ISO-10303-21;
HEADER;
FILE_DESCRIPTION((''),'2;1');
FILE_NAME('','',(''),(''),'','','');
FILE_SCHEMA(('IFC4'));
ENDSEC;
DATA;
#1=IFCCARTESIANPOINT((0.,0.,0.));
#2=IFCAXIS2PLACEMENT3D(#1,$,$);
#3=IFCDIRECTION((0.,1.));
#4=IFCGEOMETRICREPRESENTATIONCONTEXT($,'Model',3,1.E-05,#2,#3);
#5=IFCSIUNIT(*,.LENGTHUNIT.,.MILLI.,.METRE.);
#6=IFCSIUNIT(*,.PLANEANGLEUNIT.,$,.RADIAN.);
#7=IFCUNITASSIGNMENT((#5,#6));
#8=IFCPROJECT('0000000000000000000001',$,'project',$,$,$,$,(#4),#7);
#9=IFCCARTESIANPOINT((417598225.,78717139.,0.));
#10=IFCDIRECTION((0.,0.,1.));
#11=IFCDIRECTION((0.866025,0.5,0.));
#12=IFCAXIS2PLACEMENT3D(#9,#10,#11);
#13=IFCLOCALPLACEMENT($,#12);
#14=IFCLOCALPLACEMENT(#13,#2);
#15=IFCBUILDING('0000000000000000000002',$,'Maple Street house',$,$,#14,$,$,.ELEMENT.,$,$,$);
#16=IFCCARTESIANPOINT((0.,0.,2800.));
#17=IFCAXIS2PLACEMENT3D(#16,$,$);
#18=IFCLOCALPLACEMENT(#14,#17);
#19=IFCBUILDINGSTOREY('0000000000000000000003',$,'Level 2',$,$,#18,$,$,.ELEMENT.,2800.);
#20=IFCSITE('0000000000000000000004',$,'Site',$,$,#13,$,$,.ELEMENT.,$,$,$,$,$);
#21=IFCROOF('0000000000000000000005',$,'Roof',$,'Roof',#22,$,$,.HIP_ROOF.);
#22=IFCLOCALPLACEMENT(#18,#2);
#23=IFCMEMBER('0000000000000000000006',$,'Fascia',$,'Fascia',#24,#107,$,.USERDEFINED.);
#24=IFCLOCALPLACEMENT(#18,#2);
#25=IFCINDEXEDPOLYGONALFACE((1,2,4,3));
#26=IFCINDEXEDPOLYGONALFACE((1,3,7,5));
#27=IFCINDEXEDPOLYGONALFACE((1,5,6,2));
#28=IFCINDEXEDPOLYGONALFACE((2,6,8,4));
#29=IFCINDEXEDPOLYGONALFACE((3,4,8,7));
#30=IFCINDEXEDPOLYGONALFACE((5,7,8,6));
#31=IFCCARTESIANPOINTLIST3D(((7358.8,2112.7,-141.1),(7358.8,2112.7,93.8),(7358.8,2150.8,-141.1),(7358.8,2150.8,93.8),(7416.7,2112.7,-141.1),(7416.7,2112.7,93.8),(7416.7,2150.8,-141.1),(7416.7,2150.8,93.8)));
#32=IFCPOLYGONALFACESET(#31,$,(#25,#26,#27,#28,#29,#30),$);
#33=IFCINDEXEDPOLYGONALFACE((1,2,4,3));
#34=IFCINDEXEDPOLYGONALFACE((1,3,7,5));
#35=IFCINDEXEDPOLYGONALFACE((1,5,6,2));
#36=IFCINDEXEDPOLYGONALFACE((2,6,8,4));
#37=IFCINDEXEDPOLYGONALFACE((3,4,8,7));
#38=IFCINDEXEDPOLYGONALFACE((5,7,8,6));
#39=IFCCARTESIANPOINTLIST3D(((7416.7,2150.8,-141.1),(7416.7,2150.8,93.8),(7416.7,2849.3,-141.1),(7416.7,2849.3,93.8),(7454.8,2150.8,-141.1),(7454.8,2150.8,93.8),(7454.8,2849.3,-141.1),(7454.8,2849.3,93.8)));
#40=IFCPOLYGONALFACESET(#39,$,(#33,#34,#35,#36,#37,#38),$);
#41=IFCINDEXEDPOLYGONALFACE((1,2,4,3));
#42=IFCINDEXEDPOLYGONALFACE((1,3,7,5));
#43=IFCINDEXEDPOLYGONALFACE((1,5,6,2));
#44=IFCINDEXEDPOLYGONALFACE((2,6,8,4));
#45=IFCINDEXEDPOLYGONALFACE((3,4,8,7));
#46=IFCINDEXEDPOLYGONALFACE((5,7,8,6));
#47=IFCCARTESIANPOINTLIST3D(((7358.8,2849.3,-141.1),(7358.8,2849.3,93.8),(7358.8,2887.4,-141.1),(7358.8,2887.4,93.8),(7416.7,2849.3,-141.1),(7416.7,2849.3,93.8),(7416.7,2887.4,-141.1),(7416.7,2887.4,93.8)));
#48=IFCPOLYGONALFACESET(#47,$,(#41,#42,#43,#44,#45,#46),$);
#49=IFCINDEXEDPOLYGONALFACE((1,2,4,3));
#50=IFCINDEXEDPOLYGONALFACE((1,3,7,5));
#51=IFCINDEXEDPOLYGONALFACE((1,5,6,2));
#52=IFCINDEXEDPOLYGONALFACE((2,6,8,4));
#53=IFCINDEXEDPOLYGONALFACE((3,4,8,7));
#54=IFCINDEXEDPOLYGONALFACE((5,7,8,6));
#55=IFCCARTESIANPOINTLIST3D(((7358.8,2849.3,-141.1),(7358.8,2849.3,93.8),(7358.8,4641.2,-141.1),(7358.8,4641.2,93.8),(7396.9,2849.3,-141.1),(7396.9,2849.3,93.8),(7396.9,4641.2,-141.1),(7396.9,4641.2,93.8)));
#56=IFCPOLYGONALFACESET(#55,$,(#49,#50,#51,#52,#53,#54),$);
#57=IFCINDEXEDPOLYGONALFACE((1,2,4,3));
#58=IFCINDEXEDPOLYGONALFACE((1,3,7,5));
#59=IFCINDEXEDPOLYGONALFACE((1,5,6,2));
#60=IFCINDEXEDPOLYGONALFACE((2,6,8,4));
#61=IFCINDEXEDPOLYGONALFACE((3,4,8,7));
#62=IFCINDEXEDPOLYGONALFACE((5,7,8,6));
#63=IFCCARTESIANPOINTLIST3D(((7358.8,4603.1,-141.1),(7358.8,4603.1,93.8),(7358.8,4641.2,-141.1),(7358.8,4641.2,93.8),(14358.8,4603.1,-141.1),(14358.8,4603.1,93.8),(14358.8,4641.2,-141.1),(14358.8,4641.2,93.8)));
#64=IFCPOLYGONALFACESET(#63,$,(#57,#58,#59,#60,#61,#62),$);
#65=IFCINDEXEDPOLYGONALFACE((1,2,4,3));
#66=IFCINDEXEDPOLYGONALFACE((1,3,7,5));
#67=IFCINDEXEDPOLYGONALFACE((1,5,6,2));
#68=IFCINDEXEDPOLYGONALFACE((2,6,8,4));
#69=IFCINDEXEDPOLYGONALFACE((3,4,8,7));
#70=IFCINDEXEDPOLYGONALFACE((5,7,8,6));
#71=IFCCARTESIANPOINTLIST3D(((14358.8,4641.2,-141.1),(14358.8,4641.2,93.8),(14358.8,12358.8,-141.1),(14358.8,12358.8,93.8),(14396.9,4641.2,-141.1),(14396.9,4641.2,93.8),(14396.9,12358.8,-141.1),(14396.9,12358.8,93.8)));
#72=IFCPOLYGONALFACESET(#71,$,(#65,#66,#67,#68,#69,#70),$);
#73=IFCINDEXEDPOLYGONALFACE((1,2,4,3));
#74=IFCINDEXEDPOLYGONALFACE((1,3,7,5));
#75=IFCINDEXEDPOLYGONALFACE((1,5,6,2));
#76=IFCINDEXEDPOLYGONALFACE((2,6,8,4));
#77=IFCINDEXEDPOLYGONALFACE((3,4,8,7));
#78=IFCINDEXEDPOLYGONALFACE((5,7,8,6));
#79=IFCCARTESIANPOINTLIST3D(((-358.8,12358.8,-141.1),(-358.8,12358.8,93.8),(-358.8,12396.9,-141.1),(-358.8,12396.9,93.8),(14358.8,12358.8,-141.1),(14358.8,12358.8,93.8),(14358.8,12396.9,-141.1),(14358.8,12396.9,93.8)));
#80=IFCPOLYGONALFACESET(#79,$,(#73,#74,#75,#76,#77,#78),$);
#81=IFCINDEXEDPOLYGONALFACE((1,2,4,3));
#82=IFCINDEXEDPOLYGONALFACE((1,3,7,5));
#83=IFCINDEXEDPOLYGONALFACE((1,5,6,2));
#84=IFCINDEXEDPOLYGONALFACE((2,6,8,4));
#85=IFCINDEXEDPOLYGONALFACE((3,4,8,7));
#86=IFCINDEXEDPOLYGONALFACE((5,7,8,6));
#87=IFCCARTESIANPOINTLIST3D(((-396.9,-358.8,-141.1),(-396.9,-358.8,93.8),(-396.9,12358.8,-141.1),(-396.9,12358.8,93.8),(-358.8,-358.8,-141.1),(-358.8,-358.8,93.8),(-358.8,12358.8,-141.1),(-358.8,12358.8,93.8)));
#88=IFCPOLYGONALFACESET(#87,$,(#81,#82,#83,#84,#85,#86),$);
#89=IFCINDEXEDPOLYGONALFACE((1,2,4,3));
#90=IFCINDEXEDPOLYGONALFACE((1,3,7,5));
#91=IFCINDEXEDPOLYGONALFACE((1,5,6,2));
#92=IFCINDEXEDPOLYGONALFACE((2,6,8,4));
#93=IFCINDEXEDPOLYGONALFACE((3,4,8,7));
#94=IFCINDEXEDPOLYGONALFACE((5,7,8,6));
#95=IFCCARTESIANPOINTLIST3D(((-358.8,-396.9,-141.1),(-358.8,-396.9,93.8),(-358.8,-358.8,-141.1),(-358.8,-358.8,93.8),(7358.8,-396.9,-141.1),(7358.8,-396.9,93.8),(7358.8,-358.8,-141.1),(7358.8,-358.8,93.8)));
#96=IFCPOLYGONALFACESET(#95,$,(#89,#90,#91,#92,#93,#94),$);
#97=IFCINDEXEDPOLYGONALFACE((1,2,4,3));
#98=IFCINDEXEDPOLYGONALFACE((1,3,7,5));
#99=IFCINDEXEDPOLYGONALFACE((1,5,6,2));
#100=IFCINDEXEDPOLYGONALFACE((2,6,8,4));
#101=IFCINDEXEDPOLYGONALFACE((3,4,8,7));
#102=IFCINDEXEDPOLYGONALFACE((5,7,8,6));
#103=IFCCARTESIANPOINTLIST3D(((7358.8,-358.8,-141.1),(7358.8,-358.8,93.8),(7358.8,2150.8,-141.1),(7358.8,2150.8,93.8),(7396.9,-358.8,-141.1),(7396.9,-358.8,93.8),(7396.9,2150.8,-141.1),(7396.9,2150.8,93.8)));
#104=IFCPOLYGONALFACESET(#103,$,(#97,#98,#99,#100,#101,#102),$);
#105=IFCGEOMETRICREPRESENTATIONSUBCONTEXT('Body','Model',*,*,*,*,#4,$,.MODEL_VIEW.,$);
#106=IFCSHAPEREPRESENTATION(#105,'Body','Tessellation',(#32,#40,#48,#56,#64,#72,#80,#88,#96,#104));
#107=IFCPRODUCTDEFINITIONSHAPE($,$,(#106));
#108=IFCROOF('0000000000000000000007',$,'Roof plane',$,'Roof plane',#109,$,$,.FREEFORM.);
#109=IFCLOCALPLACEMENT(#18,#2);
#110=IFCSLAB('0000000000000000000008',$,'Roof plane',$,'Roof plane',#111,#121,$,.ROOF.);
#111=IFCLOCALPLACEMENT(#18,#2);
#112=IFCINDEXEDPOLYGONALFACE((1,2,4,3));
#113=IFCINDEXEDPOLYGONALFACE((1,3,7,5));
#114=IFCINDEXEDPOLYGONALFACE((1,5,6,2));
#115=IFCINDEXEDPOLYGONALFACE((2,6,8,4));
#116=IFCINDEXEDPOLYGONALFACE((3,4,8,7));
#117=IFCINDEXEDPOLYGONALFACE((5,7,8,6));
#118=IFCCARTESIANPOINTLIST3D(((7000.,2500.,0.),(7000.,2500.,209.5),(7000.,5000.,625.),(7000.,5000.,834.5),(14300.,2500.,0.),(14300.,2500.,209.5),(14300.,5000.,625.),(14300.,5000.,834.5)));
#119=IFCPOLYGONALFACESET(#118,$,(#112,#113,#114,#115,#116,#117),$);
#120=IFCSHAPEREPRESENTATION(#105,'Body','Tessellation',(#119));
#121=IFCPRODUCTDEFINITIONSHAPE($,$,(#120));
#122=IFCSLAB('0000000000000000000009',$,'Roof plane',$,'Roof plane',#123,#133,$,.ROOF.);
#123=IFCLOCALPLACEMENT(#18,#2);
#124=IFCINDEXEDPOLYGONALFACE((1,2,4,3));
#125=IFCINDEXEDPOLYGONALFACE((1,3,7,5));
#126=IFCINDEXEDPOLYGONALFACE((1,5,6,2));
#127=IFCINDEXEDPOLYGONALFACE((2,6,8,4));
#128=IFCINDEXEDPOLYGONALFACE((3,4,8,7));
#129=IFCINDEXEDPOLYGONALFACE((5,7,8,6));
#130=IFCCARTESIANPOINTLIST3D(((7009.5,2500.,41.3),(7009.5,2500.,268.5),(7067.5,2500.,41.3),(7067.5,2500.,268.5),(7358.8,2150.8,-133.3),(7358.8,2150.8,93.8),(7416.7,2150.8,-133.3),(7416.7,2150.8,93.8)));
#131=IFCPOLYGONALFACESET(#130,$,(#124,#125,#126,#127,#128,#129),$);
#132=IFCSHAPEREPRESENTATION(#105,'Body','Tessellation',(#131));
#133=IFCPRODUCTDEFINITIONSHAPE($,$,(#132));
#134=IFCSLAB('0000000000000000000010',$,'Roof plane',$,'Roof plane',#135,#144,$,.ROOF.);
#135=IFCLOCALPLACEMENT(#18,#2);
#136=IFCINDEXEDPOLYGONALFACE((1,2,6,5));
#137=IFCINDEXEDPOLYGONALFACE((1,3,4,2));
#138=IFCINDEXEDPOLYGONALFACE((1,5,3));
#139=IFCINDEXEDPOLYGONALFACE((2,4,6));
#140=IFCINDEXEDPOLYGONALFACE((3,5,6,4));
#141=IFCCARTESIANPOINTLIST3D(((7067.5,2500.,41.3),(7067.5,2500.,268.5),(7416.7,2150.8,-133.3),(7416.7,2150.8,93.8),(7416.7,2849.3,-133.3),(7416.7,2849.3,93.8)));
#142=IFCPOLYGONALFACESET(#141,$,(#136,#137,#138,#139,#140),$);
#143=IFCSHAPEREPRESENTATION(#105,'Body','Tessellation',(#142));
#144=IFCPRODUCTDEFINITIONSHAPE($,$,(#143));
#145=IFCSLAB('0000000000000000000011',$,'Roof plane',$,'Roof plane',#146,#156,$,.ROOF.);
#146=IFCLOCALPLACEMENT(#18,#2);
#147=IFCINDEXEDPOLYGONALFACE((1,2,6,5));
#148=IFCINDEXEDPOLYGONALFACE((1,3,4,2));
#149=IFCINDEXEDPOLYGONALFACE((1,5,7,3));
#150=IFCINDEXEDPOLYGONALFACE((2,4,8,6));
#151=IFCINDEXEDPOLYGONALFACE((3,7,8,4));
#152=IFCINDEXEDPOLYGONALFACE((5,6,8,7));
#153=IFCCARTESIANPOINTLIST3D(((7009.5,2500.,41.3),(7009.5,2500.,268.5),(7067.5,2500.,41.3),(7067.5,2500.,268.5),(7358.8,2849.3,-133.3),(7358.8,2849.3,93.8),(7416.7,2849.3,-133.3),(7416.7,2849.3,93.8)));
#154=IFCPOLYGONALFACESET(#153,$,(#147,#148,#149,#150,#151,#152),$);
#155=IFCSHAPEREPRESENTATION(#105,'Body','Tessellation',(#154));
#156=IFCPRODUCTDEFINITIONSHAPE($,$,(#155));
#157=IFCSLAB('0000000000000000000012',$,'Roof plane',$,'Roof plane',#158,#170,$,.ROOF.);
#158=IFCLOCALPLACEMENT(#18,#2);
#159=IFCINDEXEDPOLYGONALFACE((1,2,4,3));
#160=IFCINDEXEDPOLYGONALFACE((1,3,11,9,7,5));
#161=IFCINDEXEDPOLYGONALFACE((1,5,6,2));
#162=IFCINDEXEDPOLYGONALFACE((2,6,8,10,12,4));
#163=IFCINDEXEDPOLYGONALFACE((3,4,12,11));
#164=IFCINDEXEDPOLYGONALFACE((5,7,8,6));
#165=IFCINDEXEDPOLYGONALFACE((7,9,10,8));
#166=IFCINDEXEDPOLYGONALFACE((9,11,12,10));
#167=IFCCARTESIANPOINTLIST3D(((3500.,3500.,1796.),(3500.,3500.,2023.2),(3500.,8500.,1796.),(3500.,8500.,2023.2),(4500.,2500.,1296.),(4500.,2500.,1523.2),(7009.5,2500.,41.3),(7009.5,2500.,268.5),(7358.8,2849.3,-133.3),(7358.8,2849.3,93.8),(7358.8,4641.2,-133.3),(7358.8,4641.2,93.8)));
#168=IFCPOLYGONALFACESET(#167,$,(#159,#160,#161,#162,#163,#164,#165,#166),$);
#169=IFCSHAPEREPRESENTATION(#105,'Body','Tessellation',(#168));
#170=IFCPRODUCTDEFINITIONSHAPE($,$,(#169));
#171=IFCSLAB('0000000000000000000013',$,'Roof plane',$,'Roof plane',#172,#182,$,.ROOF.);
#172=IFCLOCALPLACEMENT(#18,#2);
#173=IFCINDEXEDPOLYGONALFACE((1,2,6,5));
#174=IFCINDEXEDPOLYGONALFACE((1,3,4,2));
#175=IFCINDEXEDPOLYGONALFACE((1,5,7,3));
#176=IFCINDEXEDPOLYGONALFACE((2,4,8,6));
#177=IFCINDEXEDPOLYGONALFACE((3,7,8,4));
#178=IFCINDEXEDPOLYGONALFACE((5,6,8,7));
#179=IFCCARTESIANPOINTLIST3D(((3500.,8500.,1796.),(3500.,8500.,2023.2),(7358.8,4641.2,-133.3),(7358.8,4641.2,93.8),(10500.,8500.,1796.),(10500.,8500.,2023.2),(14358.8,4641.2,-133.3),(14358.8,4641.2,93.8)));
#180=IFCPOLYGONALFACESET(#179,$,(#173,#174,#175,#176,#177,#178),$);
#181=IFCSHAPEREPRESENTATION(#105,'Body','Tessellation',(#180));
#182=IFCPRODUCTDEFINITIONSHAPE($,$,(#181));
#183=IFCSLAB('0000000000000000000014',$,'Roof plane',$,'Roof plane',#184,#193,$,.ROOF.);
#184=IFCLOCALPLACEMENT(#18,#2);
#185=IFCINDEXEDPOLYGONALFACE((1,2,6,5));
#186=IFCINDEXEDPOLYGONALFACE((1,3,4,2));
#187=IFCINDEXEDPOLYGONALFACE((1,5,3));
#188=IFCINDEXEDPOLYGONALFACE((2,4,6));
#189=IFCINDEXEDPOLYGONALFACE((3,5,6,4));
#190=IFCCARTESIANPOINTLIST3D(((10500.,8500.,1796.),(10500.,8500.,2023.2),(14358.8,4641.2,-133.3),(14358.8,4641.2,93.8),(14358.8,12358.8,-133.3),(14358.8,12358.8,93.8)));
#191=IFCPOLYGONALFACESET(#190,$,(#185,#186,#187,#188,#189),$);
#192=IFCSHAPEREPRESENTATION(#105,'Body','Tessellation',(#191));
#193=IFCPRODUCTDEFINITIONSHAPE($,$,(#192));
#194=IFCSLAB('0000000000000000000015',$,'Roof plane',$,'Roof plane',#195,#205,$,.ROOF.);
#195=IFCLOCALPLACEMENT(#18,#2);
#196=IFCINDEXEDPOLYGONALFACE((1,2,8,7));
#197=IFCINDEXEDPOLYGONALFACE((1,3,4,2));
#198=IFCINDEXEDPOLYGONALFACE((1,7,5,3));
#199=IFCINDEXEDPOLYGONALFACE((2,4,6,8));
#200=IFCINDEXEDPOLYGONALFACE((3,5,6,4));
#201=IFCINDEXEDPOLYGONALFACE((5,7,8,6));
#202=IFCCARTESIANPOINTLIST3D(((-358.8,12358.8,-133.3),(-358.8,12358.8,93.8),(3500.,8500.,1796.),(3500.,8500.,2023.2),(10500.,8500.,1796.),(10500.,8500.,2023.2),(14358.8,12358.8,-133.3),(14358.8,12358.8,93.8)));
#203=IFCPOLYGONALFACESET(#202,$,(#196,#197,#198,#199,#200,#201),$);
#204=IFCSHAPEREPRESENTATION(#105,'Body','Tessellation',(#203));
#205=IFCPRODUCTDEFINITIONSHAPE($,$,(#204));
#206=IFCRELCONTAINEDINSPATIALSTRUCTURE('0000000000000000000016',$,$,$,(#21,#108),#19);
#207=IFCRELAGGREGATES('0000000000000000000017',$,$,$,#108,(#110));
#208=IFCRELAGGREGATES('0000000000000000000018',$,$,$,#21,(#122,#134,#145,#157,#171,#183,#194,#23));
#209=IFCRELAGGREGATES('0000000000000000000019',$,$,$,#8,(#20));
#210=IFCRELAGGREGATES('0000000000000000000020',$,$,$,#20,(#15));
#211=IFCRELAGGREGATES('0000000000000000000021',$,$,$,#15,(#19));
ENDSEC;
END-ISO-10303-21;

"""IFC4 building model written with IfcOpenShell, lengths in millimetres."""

from ifc_helpers import new_model, si_unit, direction, frame, origin, origin_with_axes, place, context, subcontext, project, spatial, polyline, outline, extrude, element, aggregate, save


model = new_model("IFC4")

# Units and contexts
model_context = context("Model", 3, precision=1e-05, world=origin(), true_north=direction((0.0, 1.0)))
body_context = subcontext(model_context, "Body", "Model", "MODEL_VIEW")
ifc_project = project(units=[si_unit("LENGTHUNIT", "METRE", prefix="MILLI"), si_unit("PLANEANGLEUNIT", "RADIAN")], contexts=[model_context])

# Site, building, storey
site_placement = place(None, frame((417598225.0, 78717139.0, 0.0), z_axis=(0.0, 0.0, 1.0), x_axis=(0.866025, 0.5, 0.0)))
site = spatial("IfcSite", under=ifc_project, at=site_placement, Name="Site", CompositionType="ELEMENT")
building_placement = place(site_placement, origin())
building = spatial("IfcBuilding", under=site, at=building_placement, Name="Maple Street house", CompositionType="ELEMENT")
storey_placement = place(building_placement, frame((0.0, 0.0, 2800.0)))
storey = spatial("IfcBuildingStorey", under=building, at=storey_placement, Name="Level 2", CompositionType="ELEMENT", Elevation=2800.0)

# Roof, member
roof_1_placement = place(storey_placement, origin_with_axes())
roof_1 = element("IfcRoof", 1, at=roof_1_placement, inside=storey, Name="Roof", ObjectType="Roof", PredefinedType="HIP_ROOF")
member_placement = place(storey_placement, origin_with_axes())
member = element("IfcMember", 2, at=member_placement, Name="Fascia", ObjectType="Fascia", PredefinedType="USERDEFINED", context=body_context, shape_type="SweptSolid", body=[
    extrude(outline(polyline([(0.0, -234.9), (57.9, -234.9), (57.9, 0.0), (0.0, 0.0), (0.0, -234.9)])), frame((7358.8, 2150.8, 93.8), z_axis=(0.0, -1.0, 0.0), x_axis=(1.0, 0.0, 0.0)), (0.0, 0.0, 1.0), 38.1),
    extrude(outline(polyline([(0.0, -234.9), (698.5, -234.9), (698.5, 0.0), (0.0, 0.0), (0.0, -234.9)])), frame((7416.7, 2150.8, 93.8), z_axis=(1.0, 0.0, 0.0), x_axis=(0.0, 1.0, 0.0)), (0.0, 0.0, 1.0), 38.1),
    extrude(outline(polyline([(0.0, -234.9), (57.9, -234.9), (57.9, 0.0), (0.0, 0.0), (0.0, -234.9)])), frame((7416.7, 2849.3, 93.8), z_axis=(0.0, 1.0, 0.0), x_axis=(-1.0, 0.0, 0.0)), (0.0, 0.0, 1.0), 38.1),
    extrude(outline(polyline([(0.0, -234.9), (1792.0, -234.9), (1792.0, 0.0), (0.0, 0.0), (0.0, -234.9)])), frame((7358.8, 2849.3, 93.8), z_axis=(1.0, 0.0, 0.0), x_axis=(0.0, 1.0, 0.0)), (0.0, 0.0, 1.0), 38.1),
    extrude(outline(polyline([(0.0, -234.9), (7000.0, -234.9), (7000.0, 0.0), (0.0, 0.0), (0.0, -234.9)])), frame((7358.8, 4641.2, 93.8), z_axis=(0.0, -1.0, 0.0), x_axis=(1.0, 0.0, 0.0)), (0.0, 0.0, 1.0), 38.1),
    extrude(outline(polyline([(0.0, -234.9), (7717.6, -234.9), (7717.6, 0.0), (0.0, 0.0), (0.0, -234.9)])), frame((14358.8, 4641.2, 93.8), z_axis=(1.0, 0.0, 0.0), x_axis=(0.0, 1.0, 0.0)), (0.0, 0.0, 1.0), 38.1),
    extrude(outline(polyline([(0.0, -234.9), (14717.5, -234.9), (14717.5, 0.0), (0.0, 0.0), (0.0, -234.9)])), frame((14358.8, 12358.8, 93.8), z_axis=(0.0, 1.0, 0.0), x_axis=(-1.0, 0.0, 0.0)), (0.0, 0.0, 1.0), 38.1),
    extrude(outline(polyline([(0.0, -234.9), (12717.5, -234.9), (12717.5, 0.0), (0.0, 0.0), (0.0, -234.9)])), frame((-358.8, 12358.8, 93.8), z_axis=(-1.0, 0.0, 0.0), x_axis=(0.0, -1.0, 0.0)), (0.0, 0.0, 1.0), 38.1),
    extrude(outline(polyline([(0.0, -234.9), (7717.6, -234.9), (7717.6, 0.0), (0.0, 0.0), (0.0, -234.9)])), frame((-358.8, -358.8, 93.8), z_axis=(0.0, -1.0, 0.0), x_axis=(1.0, 0.0, 0.0)), (0.0, 0.0, 1.0), 38.1),
    extrude(outline(polyline([(0.0, -234.9), (2509.5, -234.9), (2509.5, 0.0), (0.0, 0.0), (0.0, -234.9)])), frame((7358.8, -358.8, 93.8), z_axis=(1.0, 0.0, 0.0), x_axis=(0.0, 1.0, 0.0)), (0.0, 0.0, 1.0), 38.1),
])

# Roof, slab
roof_2_placement = place(storey_placement, origin_with_axes())
roof_2 = element("IfcRoof", 3, at=roof_2_placement, inside=storey, Name="Roof plane", ObjectType="Roof plane", PredefinedType="FREEFORM")
slab_1_placement = place(storey_placement, origin_with_axes())
slab_1 = element("IfcSlab", 4, at=slab_1_placement, Name="Roof plane", ObjectType="Roof plane", PredefinedType="ROOF", context=body_context, shape_type="SweptSolid", body=[
    extrude(outline(polyline([(0.0, 0.0), (7300.0, 0.0), (7300.0, 2576.9), (0.0, 2576.9), (0.0, 0.0)])), frame((7000.0, 2500.0, 0.0), z_axis=(0.0, -0.242536, 0.970143), x_axis=(1.0, 0.0, 0.0)), (0.0, 0.242536, 0.970143), 209.5),
])
aggregate(roof_2, [slab_1])

# Slabs
slab_2_placement = place(storey_placement, origin_with_axes())
slab_2 = element("IfcSlab", 5, at=slab_2_placement, Name="Roof plane", ObjectType="Roof plane", PredefinedType="ROOF", context=body_context, shape_type="SweptSolid", body=[
    extrude(outline(polyline([(7358.8, 0.0), (7416.7, 0.0), (7067.5, 390.5), (7009.5, 390.5), (7358.8, 0.0)])), frame((0.0, 2150.8, -133.3), z_axis=(0.0, -0.447214, 0.894427), x_axis=(1.0, 0.0, 0.0)), (0.0, 0.447214, 0.894427), 227.2),
])
slab_3_placement = place(storey_placement, origin_with_axes())
slab_3 = element("IfcSlab", 6, at=slab_3_placement, Name="Roof plane", ObjectType="Roof plane", PredefinedType="ROOF", context=body_context, shape_type="SweptSolid", body=[
    extrude(outline(polyline([(2150.8, 0.0), (2849.3, 0.0), (2500.0, 390.5), (2150.8, 0.0)])), frame((7416.7, 0.0, -133.3), z_axis=(0.447214, 0.0, 0.894427), x_axis=(0.0, 1.0, 0.0)), (0.0, 0.447214, 0.894427), 227.2),
])
slab_4_placement = place(storey_placement, origin_with_axes())
slab_4 = element("IfcSlab", 7, at=slab_4_placement, Name="Roof plane", ObjectType="Roof plane", PredefinedType="ROOF", context=body_context, shape_type="SweptSolid", body=[
    extrude(outline(polyline([(-7416.7, 0.0), (-7358.8, 0.0), (-7009.5, 390.5), (-7067.5, 390.5), (-7416.7, 0.0)])), frame((0.0, 2849.3, -133.3), z_axis=(0.0, 0.447214, 0.894427), x_axis=(-1.0, 0.0, 0.0)), (0.0, 0.447214, 0.894427), 227.2),
])
slab_5_placement = place(storey_placement, origin_with_axes())
slab_5 = element("IfcSlab", 8, at=slab_5_placement, Name="Roof plane", ObjectType="Roof plane", PredefinedType="ROOF", context=body_context, shape_type="SweptSolid", body=[
    extrude(outline(polyline([(2849.3, 0.0), (4641.2, 0.0), (8500.0, 4314.2), (3500.0, 4314.2), (2500.0, 3196.2), (2500.0, 390.5), (2849.3, 0.0)])), frame((7358.8, 0.0, -133.3), z_axis=(0.447214, 0.0, 0.894427), x_axis=(0.0, 1.0, 0.0)), (0.0, 0.447214, 0.894427), 227.2),
])
slab_6_placement = place(storey_placement, origin_with_axes())
slab_6 = element("IfcSlab", 9, at=slab_6_placement, Name="Roof plane", ObjectType="Roof plane", PredefinedType="ROOF", context=body_context, shape_type="SweptSolid", body=[
    extrude(outline(polyline([(7358.8, 0.0), (14358.8, 0.0), (10500.0, 4314.2), (3500.0, 4314.2), (7358.8, 0.0)])), frame((0.0, 4641.2, -133.3), z_axis=(0.0, -0.447214, 0.894427), x_axis=(1.0, 0.0, 0.0)), (0.0, 0.447214, 0.894427), 227.2),
])
slab_7_placement = place(storey_placement, origin_with_axes())
slab_7 = element("IfcSlab", 10, at=slab_7_placement, Name="Roof plane", ObjectType="Roof plane", PredefinedType="ROOF", context=body_context, shape_type="SweptSolid", body=[
    extrude(outline(polyline([(4641.2, 0.0), (12358.8, 0.0), (8500.0, 4314.2), (4641.2, 0.0)])), frame((14358.8, 0.0, -133.3), z_axis=(0.447214, 0.0, 0.894427), x_axis=(0.0, 1.0, 0.0)), (0.0, 0.447214, 0.894427), 227.2),
])
slab_8_placement = place(storey_placement, origin_with_axes())
slab_8 = element("IfcSlab", 11, at=slab_8_placement, Name="Roof plane", ObjectType="Roof plane", PredefinedType="ROOF", context=body_context, shape_type="SweptSolid", body=[
    extrude(outline(polyline([(-14358.8, 0.0), (358.8, 0.0), (-3500.0, 4314.2), (-10500.0, 4314.2), (-14358.8, 0.0)])), frame((0.0, 12358.8, -133.3), z_axis=(0.0, 0.447214, 0.894427), x_axis=(-1.0, 0.0, 0.0)), (0.0, 0.447214, 0.894427), 227.2),
])

aggregate(roof_1, [slab_2, slab_3, slab_4, slab_5, slab_6, slab_7, slab_8, member])

save(model, "model.ifc")
